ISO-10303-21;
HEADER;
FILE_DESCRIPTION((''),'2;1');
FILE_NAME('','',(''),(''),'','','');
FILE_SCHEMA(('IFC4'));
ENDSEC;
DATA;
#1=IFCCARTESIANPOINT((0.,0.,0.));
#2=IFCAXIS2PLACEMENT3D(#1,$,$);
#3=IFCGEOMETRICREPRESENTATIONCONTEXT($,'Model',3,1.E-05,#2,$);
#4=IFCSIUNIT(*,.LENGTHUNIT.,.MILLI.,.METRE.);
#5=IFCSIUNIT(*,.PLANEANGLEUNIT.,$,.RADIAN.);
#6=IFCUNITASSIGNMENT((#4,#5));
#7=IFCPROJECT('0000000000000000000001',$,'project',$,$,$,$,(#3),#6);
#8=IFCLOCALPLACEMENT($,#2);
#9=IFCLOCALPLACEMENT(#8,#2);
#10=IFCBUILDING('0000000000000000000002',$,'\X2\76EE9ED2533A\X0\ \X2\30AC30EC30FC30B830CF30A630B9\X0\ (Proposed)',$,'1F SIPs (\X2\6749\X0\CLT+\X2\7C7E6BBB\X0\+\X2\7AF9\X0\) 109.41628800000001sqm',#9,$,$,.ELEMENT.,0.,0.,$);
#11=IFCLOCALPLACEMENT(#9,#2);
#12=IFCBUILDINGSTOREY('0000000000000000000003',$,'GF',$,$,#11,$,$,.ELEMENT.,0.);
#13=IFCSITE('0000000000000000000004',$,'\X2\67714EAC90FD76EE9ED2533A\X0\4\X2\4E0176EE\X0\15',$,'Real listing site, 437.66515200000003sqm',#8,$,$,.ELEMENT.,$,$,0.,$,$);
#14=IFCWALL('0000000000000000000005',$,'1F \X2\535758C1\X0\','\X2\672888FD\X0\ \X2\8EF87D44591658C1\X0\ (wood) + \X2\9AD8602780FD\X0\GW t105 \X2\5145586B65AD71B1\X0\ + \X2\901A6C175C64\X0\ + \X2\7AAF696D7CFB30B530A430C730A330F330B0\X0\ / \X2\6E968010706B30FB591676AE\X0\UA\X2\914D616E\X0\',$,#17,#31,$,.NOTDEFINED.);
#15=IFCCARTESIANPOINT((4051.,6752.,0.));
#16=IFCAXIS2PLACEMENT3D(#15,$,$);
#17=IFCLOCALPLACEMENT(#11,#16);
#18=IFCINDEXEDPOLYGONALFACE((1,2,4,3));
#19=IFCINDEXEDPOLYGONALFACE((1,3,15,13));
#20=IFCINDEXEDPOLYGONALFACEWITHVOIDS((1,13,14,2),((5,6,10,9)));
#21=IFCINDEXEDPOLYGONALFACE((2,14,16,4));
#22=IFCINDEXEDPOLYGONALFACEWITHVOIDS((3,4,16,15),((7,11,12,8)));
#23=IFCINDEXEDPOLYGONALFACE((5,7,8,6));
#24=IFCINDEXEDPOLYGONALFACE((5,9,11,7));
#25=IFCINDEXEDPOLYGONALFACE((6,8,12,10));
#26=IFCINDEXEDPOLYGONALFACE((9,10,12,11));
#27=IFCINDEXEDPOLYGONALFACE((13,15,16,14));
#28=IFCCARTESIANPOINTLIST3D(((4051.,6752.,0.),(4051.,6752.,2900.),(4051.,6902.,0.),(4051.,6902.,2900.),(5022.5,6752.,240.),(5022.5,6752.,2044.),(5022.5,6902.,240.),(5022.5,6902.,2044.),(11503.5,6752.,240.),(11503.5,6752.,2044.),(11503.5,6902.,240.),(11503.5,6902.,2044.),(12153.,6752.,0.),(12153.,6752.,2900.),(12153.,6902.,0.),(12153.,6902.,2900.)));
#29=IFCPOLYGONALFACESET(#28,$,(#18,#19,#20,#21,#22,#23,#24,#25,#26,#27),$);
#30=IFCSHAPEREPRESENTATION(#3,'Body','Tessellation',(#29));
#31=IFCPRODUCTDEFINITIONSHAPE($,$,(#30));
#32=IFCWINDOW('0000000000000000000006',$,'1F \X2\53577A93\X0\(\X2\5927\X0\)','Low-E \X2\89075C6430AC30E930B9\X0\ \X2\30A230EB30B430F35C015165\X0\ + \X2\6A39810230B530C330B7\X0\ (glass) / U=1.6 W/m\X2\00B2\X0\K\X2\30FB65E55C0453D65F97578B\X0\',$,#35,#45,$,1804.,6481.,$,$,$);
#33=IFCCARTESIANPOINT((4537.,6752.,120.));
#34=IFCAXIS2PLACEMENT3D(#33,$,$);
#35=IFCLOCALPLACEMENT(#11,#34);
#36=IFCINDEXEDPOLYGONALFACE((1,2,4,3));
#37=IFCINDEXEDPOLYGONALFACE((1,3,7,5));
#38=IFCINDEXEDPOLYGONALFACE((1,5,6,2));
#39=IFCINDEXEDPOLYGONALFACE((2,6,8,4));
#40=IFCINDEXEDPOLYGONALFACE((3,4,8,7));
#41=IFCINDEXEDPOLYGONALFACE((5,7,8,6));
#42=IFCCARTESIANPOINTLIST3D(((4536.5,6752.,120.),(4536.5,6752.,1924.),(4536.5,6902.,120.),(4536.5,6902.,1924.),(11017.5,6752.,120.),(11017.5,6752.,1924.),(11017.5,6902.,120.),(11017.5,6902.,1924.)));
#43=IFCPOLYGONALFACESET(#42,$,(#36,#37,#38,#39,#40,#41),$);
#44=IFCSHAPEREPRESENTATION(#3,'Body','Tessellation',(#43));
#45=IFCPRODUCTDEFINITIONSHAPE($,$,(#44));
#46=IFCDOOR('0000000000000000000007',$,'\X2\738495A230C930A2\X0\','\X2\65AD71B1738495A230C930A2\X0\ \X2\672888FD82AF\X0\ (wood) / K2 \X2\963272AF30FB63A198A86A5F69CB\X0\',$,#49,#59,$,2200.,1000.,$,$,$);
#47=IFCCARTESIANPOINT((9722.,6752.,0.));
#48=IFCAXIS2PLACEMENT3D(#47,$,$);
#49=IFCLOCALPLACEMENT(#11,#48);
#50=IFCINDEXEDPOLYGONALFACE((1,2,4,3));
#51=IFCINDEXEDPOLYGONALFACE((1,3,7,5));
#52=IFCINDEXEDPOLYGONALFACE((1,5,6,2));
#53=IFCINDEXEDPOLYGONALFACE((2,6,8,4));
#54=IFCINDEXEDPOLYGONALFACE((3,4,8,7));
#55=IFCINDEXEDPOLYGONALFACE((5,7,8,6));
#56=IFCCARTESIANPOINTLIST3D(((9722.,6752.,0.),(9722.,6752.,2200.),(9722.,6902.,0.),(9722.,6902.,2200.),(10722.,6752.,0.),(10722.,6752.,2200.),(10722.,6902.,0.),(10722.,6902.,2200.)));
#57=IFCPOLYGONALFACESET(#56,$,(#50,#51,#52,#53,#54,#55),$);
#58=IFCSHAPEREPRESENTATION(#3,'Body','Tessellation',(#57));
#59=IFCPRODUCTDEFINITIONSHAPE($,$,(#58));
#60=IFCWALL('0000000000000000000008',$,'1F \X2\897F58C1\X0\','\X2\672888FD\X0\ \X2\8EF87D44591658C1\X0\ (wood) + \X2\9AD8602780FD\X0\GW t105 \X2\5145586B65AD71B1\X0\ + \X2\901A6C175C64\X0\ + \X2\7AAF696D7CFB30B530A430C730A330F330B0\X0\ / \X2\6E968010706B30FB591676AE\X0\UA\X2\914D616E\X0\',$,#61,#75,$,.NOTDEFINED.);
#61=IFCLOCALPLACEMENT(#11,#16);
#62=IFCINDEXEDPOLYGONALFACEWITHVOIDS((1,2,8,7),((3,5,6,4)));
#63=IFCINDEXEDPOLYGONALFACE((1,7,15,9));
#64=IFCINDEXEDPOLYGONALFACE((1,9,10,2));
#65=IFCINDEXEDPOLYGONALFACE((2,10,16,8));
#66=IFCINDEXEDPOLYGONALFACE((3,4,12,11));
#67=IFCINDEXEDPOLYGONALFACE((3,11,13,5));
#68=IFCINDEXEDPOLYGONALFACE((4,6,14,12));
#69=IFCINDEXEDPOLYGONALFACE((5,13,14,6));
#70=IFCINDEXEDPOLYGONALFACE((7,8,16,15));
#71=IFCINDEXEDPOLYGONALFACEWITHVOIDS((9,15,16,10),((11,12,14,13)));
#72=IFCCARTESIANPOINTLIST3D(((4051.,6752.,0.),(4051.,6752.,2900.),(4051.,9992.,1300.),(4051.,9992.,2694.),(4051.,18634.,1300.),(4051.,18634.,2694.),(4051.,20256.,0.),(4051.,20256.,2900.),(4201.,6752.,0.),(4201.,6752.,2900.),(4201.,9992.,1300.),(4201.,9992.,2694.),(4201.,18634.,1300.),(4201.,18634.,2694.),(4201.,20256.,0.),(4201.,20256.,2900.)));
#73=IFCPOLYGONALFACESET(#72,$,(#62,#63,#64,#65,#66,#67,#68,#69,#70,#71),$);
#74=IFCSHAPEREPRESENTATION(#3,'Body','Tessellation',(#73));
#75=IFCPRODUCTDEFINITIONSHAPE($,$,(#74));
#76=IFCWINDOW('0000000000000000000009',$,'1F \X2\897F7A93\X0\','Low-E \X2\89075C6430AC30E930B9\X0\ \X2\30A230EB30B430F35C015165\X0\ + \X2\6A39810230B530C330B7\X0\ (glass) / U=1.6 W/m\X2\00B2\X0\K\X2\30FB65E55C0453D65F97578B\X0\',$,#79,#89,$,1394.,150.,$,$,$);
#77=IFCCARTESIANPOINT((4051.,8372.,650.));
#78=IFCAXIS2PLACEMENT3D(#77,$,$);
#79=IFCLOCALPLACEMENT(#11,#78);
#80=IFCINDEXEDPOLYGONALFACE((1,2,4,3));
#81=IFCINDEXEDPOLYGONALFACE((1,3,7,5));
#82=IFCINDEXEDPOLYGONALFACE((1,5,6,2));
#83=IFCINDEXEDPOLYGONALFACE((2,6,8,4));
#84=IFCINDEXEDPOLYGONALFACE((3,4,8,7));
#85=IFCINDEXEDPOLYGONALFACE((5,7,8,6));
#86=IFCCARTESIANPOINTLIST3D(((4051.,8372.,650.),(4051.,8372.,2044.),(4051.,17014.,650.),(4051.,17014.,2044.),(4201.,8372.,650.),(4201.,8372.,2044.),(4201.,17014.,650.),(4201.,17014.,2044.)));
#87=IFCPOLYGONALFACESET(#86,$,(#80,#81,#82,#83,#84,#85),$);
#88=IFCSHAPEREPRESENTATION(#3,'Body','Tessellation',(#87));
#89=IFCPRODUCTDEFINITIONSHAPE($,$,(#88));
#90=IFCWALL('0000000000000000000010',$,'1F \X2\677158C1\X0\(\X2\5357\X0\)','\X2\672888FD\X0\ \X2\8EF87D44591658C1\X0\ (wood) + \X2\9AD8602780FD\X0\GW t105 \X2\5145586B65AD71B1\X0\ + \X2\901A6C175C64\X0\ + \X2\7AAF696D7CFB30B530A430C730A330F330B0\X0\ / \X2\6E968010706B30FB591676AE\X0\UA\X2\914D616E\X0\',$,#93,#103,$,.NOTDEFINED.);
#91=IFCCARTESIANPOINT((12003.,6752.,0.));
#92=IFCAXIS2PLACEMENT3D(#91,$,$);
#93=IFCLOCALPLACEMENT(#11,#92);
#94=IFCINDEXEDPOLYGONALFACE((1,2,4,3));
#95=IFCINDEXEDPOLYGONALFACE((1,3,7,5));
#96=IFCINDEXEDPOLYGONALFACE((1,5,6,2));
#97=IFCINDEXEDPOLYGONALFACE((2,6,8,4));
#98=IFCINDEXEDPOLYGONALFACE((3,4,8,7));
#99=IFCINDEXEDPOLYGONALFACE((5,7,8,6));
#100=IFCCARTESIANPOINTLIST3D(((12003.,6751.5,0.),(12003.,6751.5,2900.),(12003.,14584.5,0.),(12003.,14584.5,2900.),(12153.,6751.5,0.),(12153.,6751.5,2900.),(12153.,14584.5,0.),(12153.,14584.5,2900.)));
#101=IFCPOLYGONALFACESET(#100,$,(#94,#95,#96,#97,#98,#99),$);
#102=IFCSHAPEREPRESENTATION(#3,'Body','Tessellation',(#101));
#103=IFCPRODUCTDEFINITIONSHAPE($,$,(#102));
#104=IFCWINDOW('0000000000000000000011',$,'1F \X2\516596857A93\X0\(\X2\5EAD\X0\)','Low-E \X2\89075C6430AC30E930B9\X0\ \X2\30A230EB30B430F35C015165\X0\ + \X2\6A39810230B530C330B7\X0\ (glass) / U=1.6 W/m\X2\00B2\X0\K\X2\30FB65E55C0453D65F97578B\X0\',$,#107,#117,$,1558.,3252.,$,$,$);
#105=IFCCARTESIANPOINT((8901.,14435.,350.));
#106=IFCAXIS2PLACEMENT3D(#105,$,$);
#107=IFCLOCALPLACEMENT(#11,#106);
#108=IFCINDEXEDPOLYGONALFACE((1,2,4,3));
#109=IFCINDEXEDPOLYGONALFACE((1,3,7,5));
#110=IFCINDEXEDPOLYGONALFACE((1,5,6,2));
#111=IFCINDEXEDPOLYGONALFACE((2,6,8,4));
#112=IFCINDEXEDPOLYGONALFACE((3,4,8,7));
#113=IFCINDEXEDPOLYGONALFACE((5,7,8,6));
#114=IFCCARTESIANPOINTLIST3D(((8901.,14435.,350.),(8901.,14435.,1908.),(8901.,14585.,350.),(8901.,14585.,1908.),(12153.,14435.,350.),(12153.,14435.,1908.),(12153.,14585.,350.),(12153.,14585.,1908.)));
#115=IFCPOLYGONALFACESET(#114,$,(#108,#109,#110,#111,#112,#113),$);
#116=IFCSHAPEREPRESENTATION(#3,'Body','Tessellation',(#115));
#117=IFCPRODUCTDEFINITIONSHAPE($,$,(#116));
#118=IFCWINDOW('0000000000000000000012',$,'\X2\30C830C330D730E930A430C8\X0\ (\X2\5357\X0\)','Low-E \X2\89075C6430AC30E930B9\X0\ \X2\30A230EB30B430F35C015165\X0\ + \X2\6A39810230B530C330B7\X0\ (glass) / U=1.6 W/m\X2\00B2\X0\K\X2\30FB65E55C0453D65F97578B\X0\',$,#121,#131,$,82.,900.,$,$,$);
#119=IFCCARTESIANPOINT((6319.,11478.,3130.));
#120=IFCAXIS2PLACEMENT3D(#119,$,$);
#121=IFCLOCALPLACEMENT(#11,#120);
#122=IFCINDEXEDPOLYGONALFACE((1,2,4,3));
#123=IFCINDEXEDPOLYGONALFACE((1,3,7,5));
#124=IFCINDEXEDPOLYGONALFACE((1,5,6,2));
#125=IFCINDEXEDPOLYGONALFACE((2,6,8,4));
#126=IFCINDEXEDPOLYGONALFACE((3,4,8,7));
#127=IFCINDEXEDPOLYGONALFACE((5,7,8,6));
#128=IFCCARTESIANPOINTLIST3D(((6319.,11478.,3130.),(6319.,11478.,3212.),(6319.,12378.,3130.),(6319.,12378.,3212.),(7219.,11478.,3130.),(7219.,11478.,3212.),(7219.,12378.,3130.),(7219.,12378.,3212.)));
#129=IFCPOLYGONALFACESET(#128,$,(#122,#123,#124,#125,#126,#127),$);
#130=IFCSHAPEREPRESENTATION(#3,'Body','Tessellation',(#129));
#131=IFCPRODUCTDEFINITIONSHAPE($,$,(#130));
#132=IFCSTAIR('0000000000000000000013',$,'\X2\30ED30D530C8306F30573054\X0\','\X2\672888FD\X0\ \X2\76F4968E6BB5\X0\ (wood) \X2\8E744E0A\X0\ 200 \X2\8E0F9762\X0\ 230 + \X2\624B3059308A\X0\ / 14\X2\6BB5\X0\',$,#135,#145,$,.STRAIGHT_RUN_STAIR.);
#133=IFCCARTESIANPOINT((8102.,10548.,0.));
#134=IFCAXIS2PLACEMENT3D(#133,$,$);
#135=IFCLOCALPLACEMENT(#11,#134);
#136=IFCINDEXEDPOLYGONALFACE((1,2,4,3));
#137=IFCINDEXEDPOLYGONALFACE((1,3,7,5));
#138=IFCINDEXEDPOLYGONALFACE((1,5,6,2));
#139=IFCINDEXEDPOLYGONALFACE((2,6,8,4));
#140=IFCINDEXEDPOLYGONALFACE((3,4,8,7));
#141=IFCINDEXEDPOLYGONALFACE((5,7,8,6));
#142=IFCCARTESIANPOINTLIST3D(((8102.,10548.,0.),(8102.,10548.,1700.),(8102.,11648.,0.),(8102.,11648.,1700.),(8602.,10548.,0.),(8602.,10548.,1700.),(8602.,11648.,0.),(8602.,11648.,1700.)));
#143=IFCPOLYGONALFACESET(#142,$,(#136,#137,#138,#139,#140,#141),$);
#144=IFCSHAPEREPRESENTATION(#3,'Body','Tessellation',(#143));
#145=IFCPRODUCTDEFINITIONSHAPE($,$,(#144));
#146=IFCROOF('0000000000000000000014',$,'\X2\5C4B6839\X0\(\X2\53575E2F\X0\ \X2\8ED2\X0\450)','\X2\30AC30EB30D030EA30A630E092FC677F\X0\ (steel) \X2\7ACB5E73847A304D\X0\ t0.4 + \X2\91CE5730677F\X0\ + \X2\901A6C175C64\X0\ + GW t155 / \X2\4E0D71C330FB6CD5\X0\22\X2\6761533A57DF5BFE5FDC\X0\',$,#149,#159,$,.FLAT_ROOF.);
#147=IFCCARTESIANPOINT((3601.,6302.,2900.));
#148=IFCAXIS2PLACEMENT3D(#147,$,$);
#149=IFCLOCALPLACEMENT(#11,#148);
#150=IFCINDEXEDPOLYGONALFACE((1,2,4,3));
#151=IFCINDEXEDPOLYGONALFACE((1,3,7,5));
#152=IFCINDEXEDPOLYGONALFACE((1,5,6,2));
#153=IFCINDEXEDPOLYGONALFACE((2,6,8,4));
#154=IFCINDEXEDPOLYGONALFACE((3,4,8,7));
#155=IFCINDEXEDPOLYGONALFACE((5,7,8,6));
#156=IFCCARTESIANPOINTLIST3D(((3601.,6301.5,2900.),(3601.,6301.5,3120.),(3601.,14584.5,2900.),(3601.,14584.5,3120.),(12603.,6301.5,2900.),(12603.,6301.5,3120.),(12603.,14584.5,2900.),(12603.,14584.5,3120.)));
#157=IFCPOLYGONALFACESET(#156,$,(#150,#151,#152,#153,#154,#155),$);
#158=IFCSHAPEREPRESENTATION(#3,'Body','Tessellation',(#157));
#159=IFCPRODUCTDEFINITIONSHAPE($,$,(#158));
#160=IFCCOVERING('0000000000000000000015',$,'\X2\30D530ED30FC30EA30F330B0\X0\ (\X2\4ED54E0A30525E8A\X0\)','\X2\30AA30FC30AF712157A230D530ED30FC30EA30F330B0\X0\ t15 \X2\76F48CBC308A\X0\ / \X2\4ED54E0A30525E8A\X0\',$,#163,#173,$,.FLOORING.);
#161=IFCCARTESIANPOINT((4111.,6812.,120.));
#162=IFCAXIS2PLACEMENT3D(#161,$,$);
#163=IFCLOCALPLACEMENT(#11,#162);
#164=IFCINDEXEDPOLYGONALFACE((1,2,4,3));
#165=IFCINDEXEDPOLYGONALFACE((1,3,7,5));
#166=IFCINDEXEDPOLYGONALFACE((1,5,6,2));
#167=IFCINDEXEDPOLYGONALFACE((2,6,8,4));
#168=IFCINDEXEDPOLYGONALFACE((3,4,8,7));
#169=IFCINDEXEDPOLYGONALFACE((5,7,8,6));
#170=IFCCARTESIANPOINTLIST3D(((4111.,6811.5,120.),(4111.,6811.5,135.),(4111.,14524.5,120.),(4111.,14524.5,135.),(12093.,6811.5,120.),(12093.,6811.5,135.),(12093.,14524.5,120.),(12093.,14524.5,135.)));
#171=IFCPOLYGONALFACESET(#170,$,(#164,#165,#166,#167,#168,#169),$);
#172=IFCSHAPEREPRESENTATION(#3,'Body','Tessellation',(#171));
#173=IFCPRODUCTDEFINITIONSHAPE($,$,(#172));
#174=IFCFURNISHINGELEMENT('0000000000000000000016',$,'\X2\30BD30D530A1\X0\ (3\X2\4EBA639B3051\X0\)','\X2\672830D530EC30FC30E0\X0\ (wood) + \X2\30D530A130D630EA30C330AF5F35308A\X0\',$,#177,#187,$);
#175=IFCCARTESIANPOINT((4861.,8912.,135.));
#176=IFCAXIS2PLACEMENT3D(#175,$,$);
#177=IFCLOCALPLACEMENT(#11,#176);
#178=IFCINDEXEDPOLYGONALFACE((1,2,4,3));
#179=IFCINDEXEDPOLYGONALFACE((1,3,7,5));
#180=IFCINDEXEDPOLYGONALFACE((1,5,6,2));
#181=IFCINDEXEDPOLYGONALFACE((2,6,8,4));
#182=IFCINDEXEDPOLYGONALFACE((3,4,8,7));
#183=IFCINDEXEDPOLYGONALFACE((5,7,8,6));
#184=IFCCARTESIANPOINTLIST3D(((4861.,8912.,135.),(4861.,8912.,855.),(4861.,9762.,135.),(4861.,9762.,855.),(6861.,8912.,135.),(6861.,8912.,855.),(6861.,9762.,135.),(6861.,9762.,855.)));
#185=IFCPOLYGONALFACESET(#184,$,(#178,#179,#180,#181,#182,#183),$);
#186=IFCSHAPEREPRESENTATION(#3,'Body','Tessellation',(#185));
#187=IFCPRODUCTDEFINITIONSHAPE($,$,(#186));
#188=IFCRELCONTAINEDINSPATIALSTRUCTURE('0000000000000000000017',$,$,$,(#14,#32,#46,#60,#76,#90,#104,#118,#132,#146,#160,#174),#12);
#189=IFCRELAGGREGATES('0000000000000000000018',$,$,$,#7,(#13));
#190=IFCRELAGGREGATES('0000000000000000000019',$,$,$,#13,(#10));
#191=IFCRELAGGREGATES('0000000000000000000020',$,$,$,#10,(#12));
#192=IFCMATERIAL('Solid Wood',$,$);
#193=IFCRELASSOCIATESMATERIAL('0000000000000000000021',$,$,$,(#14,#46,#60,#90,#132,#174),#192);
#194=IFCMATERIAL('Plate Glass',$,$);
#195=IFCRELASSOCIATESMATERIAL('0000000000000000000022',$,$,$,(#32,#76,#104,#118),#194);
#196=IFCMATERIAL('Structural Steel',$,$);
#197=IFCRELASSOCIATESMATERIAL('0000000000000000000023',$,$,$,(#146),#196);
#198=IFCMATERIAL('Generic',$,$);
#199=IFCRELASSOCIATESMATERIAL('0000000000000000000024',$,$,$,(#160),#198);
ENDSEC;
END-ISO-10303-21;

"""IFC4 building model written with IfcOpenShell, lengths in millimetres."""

from ifc_helpers import new_model, si_unit, frame, frame_2d, origin, place, context, project, spatial, rectangle, extrude, material, element, fill, save


model = new_model("IFC4")

# Units and contexts
model_context = context("Model", 3, precision=1e-05, world=origin())
ifc_project = project(units=[si_unit("LENGTHUNIT", "METRE", prefix="MILLI"), si_unit("PLANEANGLEUNIT", "RADIAN")], contexts=[model_context])

# Site, building, storey
site_placement = place(None, origin())
site = spatial("IfcSite", under=ifc_project, at=site_placement, Name="東京都目黒区4丁目15", ObjectType="Real listing site, 437.66515200000003sqm", CompositionType="ELEMENT", RefElevation=0.0)
building_placement = place(site_placement, origin())
building = spatial("IfcBuilding", under=site, at=building_placement, Name="目黒区 ガレージハウス (Proposed)", ObjectType="1F SIPs (杉CLT+籾殻+竹) 109.41628800000001sqm", CompositionType="ELEMENT", ElevationOfRefHeight=0.0, ElevationOfTerrain=0.0)
storey_placement = place(building_placement, origin())
storey = spatial("IfcBuildingStorey", under=building, at=storey_placement, Name="GF", CompositionType="ELEMENT", Elevation=0.0)

# Shared definitions
ifc_material_1 = material(Name="Solid Wood")

# Wall, openings, window, door
wall_1_placement = place(storey_placement, frame((4051.0, 6752.0, 0.0)))
wall_1 = element("IfcWall", 1, at=wall_1_placement, inside=storey, material=ifc_material_1, Name="1F 南壁", Description="木製 軸組外壁 (wood) + 高性能GW t105 充填断熱 + 通気層 + 窯業系サイディング / 準耐火・外皮UA配慮", PredefinedType="NOTDEFINED", context=model_context, shape_type="SweptSolid", body=[
    extrude(rectangle(XDim=8102.0, YDim=150.0, at=frame_2d((4051.0, 75.0))), frame((4051.0, 6752.0, 0.0)), (0.0, 0.0, 1.0), 2900.0),
])
opening_1_placement = place(storey_placement, frame((4537.0, 6752.0, 120.0)))
opening_1 = element("IfcOpeningElement", 2, at=opening_1_placement, cuts=wall_1, PredefinedType="NOTDEFINED", context=model_context, shape_type="SweptSolid", body=[
    extrude(rectangle(XDim=6481.0, YDim=150.0, at=frame_2d((3240.0, 75.0))), frame((4537.0, 6752.0, 120.0)), (0.0, 0.0, 1.0), 1804.0),
])
opening_2_placement = place(storey_placement, frame((9722.0, 6752.0, 0.0)))
opening_2 = element("IfcOpeningElement", 3, at=opening_2_placement, cuts=wall_1, PredefinedType="NOTDEFINED", context=model_context, shape_type="SweptSolid", body=[
    extrude(rectangle(XDim=1000.0, YDim=150.0, at=frame_2d((500.0, 75.0))), frame((9722.0, 6752.0, 0.0)), (0.0, 0.0, 1.0), 2200.0),
])
ifc_material_2 = material(Name="Plate Glass")
window_1_placement = place(storey_placement, frame((4537.0, 6752.0, 120.0)))
window_1 = element("IfcWindow", 4, at=window_1_placement, inside=storey, material=ifc_material_2, Name="1F 南窓(大)", Description="Low-E 複層ガラス アルゴン封入 + 樹脂サッシ (glass) / U=1.6 W/m²K・日射取得型", OverallHeight=1804.0, OverallWidth=6481.0, context=model_context, shape_type="SweptSolid", body=[
    extrude(rectangle(XDim=6481.0, YDim=150.0, at=frame_2d((3240.0, 75.0))), frame((4537.0, 6752.0, 120.0)), (0.0, 0.0, 1.0), 1804.0),
])
fill(opening_1, window_1)
door_1_placement = place(storey_placement, frame((9722.0, 6752.0, 0.0)))
door_1 = element("IfcDoor", 5, at=door_1_placement, inside=storey, material=ifc_material_1, Name="玄関ドア", Description="断熱玄関ドア 木製芯 (wood) / K2 防犯・採風機構", OverallHeight=2200.0, OverallWidth=1000.0, context=model_context, shape_type="SweptSolid", body=[
    extrude(rectangle(XDim=1000.0, YDim=150.0, at=frame_2d((500.0, 75.0))), frame((9722.0, 6752.0, 0.0)), (0.0, 0.0, 1.0), 2200.0),
])
fill(opening_2, door_1)

# Walls, openings, windows
wall_2_placement = place(storey_placement, frame((4051.0, 6752.0, 0.0)))
wall_2 = element("IfcWall", 6, at=wall_2_placement, inside=storey, material=ifc_material_1, Name="1F 西壁", Description="木製 軸組外壁 (wood) + 高性能GW t105 充填断熱 + 通気層 + 窯業系サイディング / 準耐火・外皮UA配慮", PredefinedType="NOTDEFINED", context=model_context, shape_type="SweptSolid", body=[
    extrude(rectangle(XDim=150.0, YDim=13504.0, at=frame_2d((75.0, 6752.0))), frame((4051.0, 6752.0, 0.0)), (0.0, 0.0, 1.0), 2900.0),
])
opening_3_placement = place(storey_placement, frame((4051.0, 8372.0, 650.0)))
opening_3 = element("IfcOpeningElement", 7, at=opening_3_placement, cuts=wall_2, PredefinedType="NOTDEFINED", context=model_context, shape_type="SweptSolid", body=[
    extrude(rectangle(XDim=150.0, YDim=8642.0, at=frame_2d((75.0, 4321.0))), frame((4051.0, 8372.0, 650.0)), (0.0, 0.0, 1.0), 1394.0),
])
window_2_placement = place(storey_placement, frame((4051.0, 8372.0, 650.0)))
window_2 = element("IfcWindow", 8, at=window_2_placement, inside=storey, material=ifc_material_2, Name="1F 西窓", Description="Low-E 複層ガラス アルゴン封入 + 樹脂サッシ (glass) / U=1.6 W/m²K・日射取得型", OverallHeight=1394.0, OverallWidth=150.0, context=model_context, shape_type="SweptSolid", body=[
    extrude(rectangle(XDim=150.0, YDim=8642.0, at=frame_2d((75.0, 4321.0))), frame((4051.0, 8372.0, 650.0)), (0.0, 0.0, 1.0), 1394.0),
])
fill(opening_3, window_2)
wall_3_placement = place(storey_placement, frame((12003.0, 6752.0, 0.0)))
wall_3 = element("IfcWall", 9, at=wall_3_placement, inside=storey, material=ifc_material_1, Name="1F 東壁(南)", Description="木製 軸組外壁 (wood) + 高性能GW t105 充填断熱 + 通気層 + 窯業系サイディング / 準耐火・外皮UA配慮", PredefinedType="NOTDEFINED", context=model_context, shape_type="SweptSolid", body=[
    extrude(rectangle(XDim=150.0, YDim=7833.0, at=frame_2d((75.0, 3916.0))), frame((12003.0, 6752.0, 0.0)), (0.0, 0.0, 1.0), 2900.0),
])
opening_4_placement = place(storey_placement, frame((8901.0, 14435.0, 350.0)))
opening_4 = element("IfcOpeningElement", 10, at=opening_4_placement, cuts=wall_3, PredefinedType="NOTDEFINED", context=model_context, shape_type="SweptSolid", body=[
    extrude(rectangle(XDim=3252.0, YDim=150.0, at=frame_2d((1626.0, 75.0))), frame((8901.0, 14435.0, 350.0)), (0.0, 0.0, 1.0), 1558.0),
])
window_3_placement = place(storey_placement, frame((8901.0, 14435.0, 350.0)))
window_3 = element("IfcWindow", 11, at=window_3_placement, inside=storey, material=ifc_material_2, Name="1F 入隅窓(庭)", Description="Low-E 複層ガラス アルゴン封入 + 樹脂サッシ (glass) / U=1.6 W/m²K・日射取得型", OverallHeight=1558.0, OverallWidth=3252.0, context=model_context, shape_type="SweptSolid", body=[
    extrude(rectangle(XDim=3252.0, YDim=150.0, at=frame_2d((1626.0, 75.0))), frame((8901.0, 14435.0, 350.0)), (0.0, 0.0, 1.0), 1558.0),
])
fill(opening_4, window_3)

# Window
window_4_placement = place(storey_placement, frame((6319.0, 11478.0, 3130.0)))
element("IfcWindow", 12, at=window_4_placement, inside=storey, material=ifc_material_2, Name="トップライト (南)", Description="Low-E 複層ガラス アルゴン封入 + 樹脂サッシ (glass) / U=1.6 W/m²K・日射取得型", OverallHeight=82.0, OverallWidth=900.0, context=model_context, shape_type="SweptSolid", body=[
    extrude(rectangle(XDim=900.0, YDim=900.0, at=frame_2d((450.0, 450.0))), frame((6319.0, 11478.0, 3130.0)), (0.0, 0.0, 1.0), 82.0),
])

# Stair
stair_placement = place(storey_placement, frame((8102.0, 10548.0, 0.0)))
element("IfcStair", 13, at=stair_placement, inside=storey, material=ifc_material_1, Name="ロフトはしご", Description="木製 直階段 (wood) 蹴上 200 踏面 230 + 手すり / 14段", PredefinedType="STRAIGHT_RUN_STAIR", context=model_context, shape_type="SweptSolid", body=[
    extrude(rectangle(XDim=500.0, YDim=1100.0, at=frame_2d((250.0, 550.0))), frame((8102.0, 10548.0, 0.0)), (0.0, 0.0, 1.0), 1700.0),
])

# Roof
ifc_material_3 = material(Name="Structural Steel")
roof_placement = place(storey_placement, frame((3601.0, 6302.0, 2900.0)))
element("IfcRoof", 14, at=roof_placement, inside=storey, material=ifc_material_3, Name="屋根(南帯 軒450)", Description="ガルバリウム鋼板 (steel) 立平葺き t0.4 + 野地板 + 通気層 + GW t155 / 不燃・法22条区域対応", PredefinedType="FLAT_ROOF", context=model_context, shape_type="SweptSolid", body=[
    extrude(rectangle(XDim=9002.0, YDim=8283.0, at=frame_2d((4501.0, 4141.0))), frame((3601.0, 6302.0, 2900.0)), (0.0, 0.0, 1.0), 220.0),
])

# Covering
ifc_material_4 = material(Name="Generic")
covering_placement = place(storey_placement, frame((4111.0, 6812.0, 120.0)))
element("IfcCovering", 15, at=covering_placement, inside=storey, material=ifc_material_4, Name="フローリング (仕上げ床)", Description="オーク無垢フローリング t15 直貼り / 仕上げ床", PredefinedType="FLOORING", context=model_context, shape_type="SweptSolid", body=[
    extrude(rectangle(XDim=7982.0, YDim=7713.0, at=frame_2d((3991.0, 3856.0))), frame((4111.0, 6812.0, 120.0)), (0.0, 0.0, 1.0), 15.0),
])

# Furnishing element
furnishing_1_placement = place(storey_placement, frame((4861.0, 8912.0, 135.0)))
element("IfcFurnishingElement", 16, at=furnishing_1_placement, inside=storey, material=ifc_material_1, Name="ソファ (3人掛け)", Description="木フレーム (wood) + ファブリック張り", context=model_context, shape_type="SweptSolid", body=[
    extrude(rectangle(XDim=2000.0, YDim=850.0, at=frame_2d((1000.0, 425.0))), frame((4861.0, 8912.0, 135.0)), (0.0, 0.0, 1.0), 720.0),
])

save(model, "model.ifc")
